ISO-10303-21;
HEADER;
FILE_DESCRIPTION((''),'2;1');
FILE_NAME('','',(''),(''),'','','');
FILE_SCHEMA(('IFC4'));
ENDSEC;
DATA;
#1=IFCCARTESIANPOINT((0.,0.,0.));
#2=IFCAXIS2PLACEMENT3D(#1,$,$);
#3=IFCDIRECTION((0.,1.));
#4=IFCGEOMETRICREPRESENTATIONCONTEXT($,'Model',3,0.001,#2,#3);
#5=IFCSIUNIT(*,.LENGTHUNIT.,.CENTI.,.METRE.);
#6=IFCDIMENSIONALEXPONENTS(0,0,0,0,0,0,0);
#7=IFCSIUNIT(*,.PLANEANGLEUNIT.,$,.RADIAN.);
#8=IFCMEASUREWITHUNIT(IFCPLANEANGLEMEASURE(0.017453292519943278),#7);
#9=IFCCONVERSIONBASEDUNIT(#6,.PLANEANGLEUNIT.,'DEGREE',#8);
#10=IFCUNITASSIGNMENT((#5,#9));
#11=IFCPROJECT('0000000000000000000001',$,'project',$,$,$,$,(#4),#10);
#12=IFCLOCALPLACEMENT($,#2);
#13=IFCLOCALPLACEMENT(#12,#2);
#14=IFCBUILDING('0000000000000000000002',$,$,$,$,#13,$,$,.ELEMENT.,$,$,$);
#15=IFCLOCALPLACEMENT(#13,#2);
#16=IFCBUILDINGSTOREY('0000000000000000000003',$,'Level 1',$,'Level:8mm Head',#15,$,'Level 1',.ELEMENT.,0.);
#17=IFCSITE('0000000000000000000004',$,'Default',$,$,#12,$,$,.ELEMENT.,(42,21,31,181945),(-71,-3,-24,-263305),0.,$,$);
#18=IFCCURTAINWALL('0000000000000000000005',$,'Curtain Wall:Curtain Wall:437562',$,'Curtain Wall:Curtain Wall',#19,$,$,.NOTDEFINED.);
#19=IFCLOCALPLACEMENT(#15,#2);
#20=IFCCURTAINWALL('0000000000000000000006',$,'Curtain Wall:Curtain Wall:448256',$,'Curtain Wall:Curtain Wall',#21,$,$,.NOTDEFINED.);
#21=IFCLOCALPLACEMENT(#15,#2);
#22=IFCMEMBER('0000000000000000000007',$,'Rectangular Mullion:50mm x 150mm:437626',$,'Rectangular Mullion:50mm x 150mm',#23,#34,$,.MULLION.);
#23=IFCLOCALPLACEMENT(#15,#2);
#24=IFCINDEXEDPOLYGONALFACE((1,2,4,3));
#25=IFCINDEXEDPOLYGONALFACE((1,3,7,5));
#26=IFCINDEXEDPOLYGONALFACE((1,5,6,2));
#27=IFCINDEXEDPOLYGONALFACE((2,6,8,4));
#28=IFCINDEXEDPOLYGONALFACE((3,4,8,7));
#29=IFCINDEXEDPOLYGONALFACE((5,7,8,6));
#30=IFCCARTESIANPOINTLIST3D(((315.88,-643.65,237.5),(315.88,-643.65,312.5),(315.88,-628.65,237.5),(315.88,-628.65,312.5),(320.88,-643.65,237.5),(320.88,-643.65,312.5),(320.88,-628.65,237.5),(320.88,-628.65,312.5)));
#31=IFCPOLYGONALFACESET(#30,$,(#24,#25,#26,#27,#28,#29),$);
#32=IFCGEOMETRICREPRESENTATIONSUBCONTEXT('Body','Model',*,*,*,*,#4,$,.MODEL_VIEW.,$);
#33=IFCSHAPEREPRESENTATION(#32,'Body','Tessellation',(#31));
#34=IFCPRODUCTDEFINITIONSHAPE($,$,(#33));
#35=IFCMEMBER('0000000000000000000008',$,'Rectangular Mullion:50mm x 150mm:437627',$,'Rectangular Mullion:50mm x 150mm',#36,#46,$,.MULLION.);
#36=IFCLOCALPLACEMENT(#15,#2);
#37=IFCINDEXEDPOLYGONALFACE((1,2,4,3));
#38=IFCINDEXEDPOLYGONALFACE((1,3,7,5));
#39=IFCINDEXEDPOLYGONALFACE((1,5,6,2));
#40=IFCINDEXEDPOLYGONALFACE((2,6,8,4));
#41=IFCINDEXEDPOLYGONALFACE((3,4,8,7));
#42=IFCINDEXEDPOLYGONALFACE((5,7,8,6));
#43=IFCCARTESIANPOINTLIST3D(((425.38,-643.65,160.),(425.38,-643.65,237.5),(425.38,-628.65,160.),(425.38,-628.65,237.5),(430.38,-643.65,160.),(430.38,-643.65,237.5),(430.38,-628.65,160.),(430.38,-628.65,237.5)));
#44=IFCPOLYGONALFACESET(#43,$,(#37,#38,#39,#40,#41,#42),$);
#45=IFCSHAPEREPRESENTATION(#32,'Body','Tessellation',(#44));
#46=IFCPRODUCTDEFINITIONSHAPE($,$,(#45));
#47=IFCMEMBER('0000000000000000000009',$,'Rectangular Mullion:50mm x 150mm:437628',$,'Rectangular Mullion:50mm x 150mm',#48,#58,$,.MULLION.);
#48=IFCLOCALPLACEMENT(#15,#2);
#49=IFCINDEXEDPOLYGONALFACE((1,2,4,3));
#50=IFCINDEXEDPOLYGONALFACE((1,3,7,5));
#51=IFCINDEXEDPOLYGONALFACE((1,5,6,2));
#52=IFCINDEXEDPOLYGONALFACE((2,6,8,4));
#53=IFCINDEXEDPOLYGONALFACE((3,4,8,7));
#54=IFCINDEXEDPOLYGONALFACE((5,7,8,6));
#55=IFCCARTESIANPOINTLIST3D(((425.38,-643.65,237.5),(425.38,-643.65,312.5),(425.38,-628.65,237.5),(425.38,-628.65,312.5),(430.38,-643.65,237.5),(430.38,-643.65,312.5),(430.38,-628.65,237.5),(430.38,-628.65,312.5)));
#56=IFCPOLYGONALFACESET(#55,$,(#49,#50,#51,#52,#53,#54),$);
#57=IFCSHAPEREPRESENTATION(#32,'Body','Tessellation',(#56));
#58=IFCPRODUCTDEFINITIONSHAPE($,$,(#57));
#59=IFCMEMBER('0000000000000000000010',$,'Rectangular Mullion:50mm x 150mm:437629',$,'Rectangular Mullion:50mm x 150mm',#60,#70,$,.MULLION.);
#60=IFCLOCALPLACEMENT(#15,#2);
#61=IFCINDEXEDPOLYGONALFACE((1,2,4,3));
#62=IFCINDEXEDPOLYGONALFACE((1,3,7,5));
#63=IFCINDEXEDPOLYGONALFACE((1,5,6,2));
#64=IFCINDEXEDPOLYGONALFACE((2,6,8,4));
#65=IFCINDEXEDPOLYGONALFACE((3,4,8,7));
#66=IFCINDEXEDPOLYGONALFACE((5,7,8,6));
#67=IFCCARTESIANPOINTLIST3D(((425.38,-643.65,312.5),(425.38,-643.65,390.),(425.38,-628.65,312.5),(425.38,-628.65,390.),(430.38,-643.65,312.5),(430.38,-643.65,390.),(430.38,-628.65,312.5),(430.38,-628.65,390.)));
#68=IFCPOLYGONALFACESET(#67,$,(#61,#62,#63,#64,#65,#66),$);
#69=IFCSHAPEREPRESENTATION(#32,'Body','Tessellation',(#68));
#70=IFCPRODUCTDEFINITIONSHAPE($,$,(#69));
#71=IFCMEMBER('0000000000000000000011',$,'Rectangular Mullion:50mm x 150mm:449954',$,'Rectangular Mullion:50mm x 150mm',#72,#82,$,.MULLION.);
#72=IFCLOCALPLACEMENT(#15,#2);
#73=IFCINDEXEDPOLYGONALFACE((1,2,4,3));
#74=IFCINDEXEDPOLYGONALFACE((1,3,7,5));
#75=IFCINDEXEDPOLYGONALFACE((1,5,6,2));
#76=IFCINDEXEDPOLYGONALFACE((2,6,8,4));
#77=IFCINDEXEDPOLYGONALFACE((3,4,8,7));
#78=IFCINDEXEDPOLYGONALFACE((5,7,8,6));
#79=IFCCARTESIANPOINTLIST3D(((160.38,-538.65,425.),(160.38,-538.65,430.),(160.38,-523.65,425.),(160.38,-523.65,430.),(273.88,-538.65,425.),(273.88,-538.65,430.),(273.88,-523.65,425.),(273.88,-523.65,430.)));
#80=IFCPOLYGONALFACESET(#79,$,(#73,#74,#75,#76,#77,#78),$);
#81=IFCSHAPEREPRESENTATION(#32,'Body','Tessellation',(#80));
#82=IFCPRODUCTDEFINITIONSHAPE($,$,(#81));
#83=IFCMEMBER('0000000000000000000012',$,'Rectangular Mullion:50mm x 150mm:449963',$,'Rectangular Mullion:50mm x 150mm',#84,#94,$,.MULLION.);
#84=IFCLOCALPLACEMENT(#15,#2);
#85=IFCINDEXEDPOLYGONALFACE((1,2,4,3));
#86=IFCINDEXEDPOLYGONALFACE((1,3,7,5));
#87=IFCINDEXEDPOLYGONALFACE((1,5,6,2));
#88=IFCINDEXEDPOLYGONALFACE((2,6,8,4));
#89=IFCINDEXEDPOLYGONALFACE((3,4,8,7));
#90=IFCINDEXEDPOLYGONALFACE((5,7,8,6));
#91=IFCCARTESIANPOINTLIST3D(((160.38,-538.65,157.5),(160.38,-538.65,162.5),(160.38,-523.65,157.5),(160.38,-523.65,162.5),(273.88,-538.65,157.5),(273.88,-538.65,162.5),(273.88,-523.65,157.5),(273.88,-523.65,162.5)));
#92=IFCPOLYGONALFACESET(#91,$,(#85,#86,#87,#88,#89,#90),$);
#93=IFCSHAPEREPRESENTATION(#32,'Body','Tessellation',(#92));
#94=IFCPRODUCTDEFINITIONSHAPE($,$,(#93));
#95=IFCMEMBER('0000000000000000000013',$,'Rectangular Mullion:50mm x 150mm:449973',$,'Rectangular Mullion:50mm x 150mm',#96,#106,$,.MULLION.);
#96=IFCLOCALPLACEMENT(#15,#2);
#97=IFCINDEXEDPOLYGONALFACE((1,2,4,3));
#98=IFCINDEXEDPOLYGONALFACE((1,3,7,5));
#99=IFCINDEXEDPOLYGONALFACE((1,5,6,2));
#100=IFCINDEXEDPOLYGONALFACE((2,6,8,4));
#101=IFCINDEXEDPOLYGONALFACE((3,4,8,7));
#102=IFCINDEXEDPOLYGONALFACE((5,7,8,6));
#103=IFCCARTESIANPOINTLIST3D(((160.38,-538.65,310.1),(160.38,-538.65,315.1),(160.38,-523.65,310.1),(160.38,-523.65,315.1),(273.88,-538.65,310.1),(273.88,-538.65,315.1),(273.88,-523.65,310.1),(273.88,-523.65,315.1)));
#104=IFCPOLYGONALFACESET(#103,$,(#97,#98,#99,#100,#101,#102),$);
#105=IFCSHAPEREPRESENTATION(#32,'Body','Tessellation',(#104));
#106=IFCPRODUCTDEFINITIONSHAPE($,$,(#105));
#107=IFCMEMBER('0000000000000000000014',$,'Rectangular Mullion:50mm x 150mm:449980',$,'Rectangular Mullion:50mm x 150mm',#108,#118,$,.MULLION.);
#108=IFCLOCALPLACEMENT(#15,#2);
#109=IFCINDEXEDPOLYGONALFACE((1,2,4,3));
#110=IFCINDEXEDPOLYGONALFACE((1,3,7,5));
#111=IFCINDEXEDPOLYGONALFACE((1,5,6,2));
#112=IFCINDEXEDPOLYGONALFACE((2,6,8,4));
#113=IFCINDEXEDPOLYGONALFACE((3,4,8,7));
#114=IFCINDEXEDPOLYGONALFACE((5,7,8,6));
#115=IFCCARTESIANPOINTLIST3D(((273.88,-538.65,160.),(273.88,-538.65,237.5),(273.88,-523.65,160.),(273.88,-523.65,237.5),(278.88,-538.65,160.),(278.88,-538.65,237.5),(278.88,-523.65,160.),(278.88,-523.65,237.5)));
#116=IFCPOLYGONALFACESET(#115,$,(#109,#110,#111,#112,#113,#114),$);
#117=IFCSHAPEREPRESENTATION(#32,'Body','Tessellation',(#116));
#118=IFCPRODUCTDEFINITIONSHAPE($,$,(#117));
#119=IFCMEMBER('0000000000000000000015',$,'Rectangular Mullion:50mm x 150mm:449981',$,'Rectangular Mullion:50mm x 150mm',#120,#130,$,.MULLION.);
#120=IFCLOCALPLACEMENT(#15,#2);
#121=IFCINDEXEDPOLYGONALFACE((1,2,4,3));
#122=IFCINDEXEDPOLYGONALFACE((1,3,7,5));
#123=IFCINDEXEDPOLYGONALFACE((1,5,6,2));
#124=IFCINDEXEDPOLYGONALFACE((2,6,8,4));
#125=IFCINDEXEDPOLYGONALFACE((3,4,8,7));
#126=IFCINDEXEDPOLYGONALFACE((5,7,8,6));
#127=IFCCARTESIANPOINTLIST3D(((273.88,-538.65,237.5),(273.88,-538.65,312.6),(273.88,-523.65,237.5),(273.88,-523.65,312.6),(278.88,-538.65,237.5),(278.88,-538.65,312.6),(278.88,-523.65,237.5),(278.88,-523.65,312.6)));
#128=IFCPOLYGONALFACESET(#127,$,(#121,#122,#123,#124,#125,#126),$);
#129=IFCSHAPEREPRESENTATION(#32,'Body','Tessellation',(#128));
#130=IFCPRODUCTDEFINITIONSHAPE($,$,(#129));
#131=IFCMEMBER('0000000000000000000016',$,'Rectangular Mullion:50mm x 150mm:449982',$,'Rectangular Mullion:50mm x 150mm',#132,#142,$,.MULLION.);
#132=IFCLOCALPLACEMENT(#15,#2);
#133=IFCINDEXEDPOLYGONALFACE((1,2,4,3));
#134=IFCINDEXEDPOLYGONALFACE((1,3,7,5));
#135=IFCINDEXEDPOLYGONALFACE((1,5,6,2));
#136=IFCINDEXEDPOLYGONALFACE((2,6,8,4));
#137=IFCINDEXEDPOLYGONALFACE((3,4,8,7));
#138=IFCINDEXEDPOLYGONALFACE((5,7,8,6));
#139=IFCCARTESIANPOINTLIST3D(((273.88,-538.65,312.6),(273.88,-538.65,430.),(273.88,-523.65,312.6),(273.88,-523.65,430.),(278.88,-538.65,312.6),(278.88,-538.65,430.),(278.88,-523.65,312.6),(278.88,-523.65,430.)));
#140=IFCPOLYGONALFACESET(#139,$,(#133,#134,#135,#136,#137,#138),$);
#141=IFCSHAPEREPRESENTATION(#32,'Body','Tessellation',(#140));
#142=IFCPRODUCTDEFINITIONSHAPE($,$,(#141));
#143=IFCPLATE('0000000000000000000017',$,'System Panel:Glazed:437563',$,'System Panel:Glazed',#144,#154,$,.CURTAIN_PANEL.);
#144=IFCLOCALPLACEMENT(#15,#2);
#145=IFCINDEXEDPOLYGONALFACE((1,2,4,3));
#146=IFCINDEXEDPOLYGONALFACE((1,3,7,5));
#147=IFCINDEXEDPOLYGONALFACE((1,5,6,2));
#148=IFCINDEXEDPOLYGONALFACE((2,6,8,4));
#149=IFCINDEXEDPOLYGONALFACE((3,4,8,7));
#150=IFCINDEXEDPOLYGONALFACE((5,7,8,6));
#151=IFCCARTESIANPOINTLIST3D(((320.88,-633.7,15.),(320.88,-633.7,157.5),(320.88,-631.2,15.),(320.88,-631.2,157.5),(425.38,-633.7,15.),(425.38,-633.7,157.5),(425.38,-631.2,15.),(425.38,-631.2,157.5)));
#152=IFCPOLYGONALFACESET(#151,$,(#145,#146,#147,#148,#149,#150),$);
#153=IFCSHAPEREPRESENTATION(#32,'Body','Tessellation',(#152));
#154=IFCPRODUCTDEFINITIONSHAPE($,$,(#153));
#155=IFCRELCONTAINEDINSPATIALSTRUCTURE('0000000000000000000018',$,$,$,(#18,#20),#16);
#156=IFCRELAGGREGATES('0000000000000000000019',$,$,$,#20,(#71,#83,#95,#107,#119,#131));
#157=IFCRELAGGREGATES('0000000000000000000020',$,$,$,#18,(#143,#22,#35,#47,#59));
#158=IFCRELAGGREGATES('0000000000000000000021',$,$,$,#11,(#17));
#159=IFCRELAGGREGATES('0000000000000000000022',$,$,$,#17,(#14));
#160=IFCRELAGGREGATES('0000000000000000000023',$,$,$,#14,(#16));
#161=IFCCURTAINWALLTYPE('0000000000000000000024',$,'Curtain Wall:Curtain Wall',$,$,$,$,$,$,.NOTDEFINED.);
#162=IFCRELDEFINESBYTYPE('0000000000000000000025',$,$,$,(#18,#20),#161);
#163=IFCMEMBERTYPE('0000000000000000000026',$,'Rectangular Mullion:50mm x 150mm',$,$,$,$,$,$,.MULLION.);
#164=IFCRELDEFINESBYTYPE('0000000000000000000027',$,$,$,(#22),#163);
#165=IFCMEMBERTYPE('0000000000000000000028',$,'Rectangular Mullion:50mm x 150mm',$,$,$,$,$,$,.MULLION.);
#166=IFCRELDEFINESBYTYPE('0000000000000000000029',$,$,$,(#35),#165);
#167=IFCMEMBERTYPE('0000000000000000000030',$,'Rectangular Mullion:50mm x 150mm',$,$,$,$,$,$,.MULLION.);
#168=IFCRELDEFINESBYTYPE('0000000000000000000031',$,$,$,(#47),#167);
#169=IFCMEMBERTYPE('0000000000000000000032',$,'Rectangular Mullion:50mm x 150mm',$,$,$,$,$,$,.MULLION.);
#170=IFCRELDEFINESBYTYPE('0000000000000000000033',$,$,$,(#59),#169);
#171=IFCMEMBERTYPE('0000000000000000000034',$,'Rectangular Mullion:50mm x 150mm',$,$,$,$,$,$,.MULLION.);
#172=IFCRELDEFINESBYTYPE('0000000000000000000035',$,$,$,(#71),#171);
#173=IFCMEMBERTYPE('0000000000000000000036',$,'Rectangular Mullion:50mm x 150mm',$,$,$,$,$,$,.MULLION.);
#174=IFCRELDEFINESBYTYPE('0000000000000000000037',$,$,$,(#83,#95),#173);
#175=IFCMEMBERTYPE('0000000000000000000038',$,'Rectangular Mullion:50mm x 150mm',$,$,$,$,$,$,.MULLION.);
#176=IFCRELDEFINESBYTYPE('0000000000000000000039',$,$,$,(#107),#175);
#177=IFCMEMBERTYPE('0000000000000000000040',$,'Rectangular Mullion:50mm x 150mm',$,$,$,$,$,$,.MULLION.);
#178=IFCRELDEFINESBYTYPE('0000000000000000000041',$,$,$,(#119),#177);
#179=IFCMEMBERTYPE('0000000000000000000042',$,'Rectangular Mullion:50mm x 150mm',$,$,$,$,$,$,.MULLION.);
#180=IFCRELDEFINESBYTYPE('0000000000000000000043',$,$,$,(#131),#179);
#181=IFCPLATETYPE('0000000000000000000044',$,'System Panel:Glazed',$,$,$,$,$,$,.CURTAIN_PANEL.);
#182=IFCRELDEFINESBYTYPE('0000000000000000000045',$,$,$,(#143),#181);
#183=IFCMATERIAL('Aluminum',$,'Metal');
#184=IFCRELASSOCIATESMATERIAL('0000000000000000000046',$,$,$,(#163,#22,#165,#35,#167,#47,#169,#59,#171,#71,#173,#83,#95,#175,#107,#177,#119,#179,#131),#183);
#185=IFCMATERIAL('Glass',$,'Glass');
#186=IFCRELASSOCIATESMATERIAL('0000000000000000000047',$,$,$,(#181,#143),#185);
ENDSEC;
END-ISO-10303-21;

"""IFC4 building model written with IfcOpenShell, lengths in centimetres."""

from ifc_helpers import new_model, entity, si_unit, converted_unit, direction, frame, origin, place, context, subcontext, project, spatial, indexed_curve, outline, extrude, source, transform, mapped, material, type_object, type_shapes, element, aggregate, save


model = new_model("IFC4")

# Units and contexts
model_context = context("Model", 3, precision=0.001, world=origin(), true_north=direction((0.0, 1.0)))
body_context = subcontext(model_context, "Body", "Model", "MODEL_VIEW")
ifc_project = project(units=[si_unit("LENGTHUNIT", "METRE", prefix="CENTI"), converted_unit("PLANEANGLEUNIT", "DEGREE", entity("IfcPlaneAngleMeasure", 0.017453292519943278), si_unit("PLANEANGLEUNIT", "RADIAN"), dimensions=[0, 0, 0, 0, 0, 0, 0])], contexts=[model_context])

# Site, building, storey
site_placement = place(None, origin())
site = spatial("IfcSite", under=ifc_project, at=site_placement, Name="Default", CompositionType="ELEMENT", RefLatitude=(42, 21, 31, 181945), RefLongitude=(-71, -3, -24, -263305), RefElevation=0.0)
building_placement = place(site_placement, origin())
building = spatial("IfcBuilding", under=site, at=building_placement, CompositionType="ELEMENT")
storey_placement = place(building_placement, origin())
storey = spatial("IfcBuildingStorey", under=building, at=storey_placement, Name="Level 1", ObjectType="Level:8mm Head", LongName="Level 1", CompositionType="ELEMENT", Elevation=0.0)

# Curtain wall
curtain_wall_type = type_object("IfcCurtainWallType", Name="Curtain Wall:Curtain Wall", PredefinedType="NOTDEFINED")
curtain_wall_1_placement = place(storey_placement, origin())
curtain_wall_1 = element("IfcCurtainWall", 1, at=curtain_wall_1_placement, inside=storey, type_object=curtain_wall_type, Name="Curtain Wall:Curtain Wall:437562", ObjectType="Curtain Wall:Curtain Wall", PredefinedType="NOTDEFINED")
ifc_material_1 = material(Name="Aluminum", Category="Metal")

# Curtain wall
curtain_wall_2_placement = place(storey_placement, origin())
curtain_wall_2 = element("IfcCurtainWall", 2, at=curtain_wall_2_placement, inside=storey, type_object=curtain_wall_type, Name="Curtain Wall:Curtain Wall:448256", ObjectType="Curtain Wall:Curtain Wall", PredefinedType="NOTDEFINED")

# Members
member_type_1 = type_object("IfcMemberType", Name="Rectangular Mullion:50mm x 150mm", PredefinedType="MULLION", material=ifc_material_1)
shared_shape_1 = source(origin(), body_context, "Body", "SweptSolid", [
    extrude(outline(indexed_curve([(-2.5, -7.5), (2.5, -7.5), (2.5, 7.5), (-2.5, 7.5), (-2.5, -7.5)], self_intersect=False)), frame((-2.5, 0.0, -75.0), z_axis=(0.0, 0.0, 1.0), x_axis=(-1.0, 0.0, 0.0)), (0.0, 0.0, 1.0), 75.0),
])
type_shapes(member_type_1, [shared_shape_1])
member_1_placement = place(curtain_wall_1_placement, frame((315.88, -636.15, 312.5), z_axis=(0.0, 0.0, 1.0), x_axis=(-1.0, 0.0, 0.0)))
member_1 = element("IfcMember", 3, at=member_1_placement, type_object=member_type_1, material=ifc_material_1, Name="Rectangular Mullion:50mm x 150mm:437626", ObjectType="Rectangular Mullion:50mm x 150mm", PredefinedType="MULLION", context=body_context, shape_type="MappedRepresentation", body=[
    mapped(shared_shape_1, transform((0.0, 0.0, 0.0), scale=1.0)),
])
member_type_2 = type_object("IfcMemberType", Name="Rectangular Mullion:50mm x 150mm", PredefinedType="MULLION", material=ifc_material_1)
shared_shape_2 = source(origin(), body_context, "Body", "SweptSolid", [
    extrude(outline(indexed_curve([(-2.5, -7.5), (2.5, -7.5), (2.5, 7.5), (-2.5, 7.5), (-2.5, -7.5)], self_intersect=False)), frame((0.0, 0.0, -77.5), z_axis=(0.0, 0.0, 1.0), x_axis=(-1.0, 0.0, 0.0)), (0.0, 0.0, 1.0), 77.5),
])
type_shapes(member_type_2, [shared_shape_2])
member_2_placement = place(curtain_wall_1_placement, frame((427.88, -636.15, 160.0), z_axis=(0.0, 0.0, -1.0), x_axis=(1.0, 0.0, 0.0)))
member_2 = element("IfcMember", 4, at=member_2_placement, type_object=member_type_2, material=ifc_material_1, Name="Rectangular Mullion:50mm x 150mm:437627", ObjectType="Rectangular Mullion:50mm x 150mm", PredefinedType="MULLION", context=body_context, shape_type="MappedRepresentation", body=[
    mapped(shared_shape_2, transform((0.0, 0.0, 0.0), scale=1.0)),
])
member_type_3 = type_object("IfcMemberType", Name="Rectangular Mullion:50mm x 150mm", PredefinedType="MULLION", material=ifc_material_1)
shared_shape_3 = source(origin(), body_context, "Body", "SweptSolid", [
    extrude(outline(indexed_curve([(-2.5, -7.5), (2.5, -7.5), (2.5, 7.5), (-2.5, 7.5), (-2.5, -7.5)], self_intersect=False)), frame((0.0, 0.0, -75.0), z_axis=(0.0, 0.0, 1.0), x_axis=(-1.0, 0.0, 0.0)), (0.0, 0.0, 1.0), 75.0),
])
type_shapes(member_type_3, [shared_shape_3])
member_3_placement = place(curtain_wall_1_placement, frame((427.88, -636.15, 237.5), z_axis=(0.0, 0.0, -1.0), x_axis=(1.0, 0.0, 0.0)))
member_3 = element("IfcMember", 5, at=member_3_placement, type_object=member_type_3, material=ifc_material_1, Name="Rectangular Mullion:50mm x 150mm:437628", ObjectType="Rectangular Mullion:50mm x 150mm", PredefinedType="MULLION", context=body_context, shape_type="MappedRepresentation", body=[
    mapped(shared_shape_3, transform((0.0, 0.0, 0.0), scale=1.0)),
])
member_type_4 = type_object("IfcMemberType", Name="Rectangular Mullion:50mm x 150mm", PredefinedType="MULLION", material=ifc_material_1)
shared_shape_4 = source(origin(), body_context, "Body", "SweptSolid", [
    extrude(outline(indexed_curve([(-2.5, -7.5), (2.5, -7.5), (2.5, 7.5), (-2.5, 7.5), (-2.5, -7.5)], self_intersect=False)), frame((0.0, 0.0, -77.5), z_axis=(0.0, 0.0, 1.0), x_axis=(-1.0, 0.0, 0.0)), (0.0, 0.0, 1.0), 77.5),
])
type_shapes(member_type_4, [shared_shape_4])
member_4_placement = place(curtain_wall_1_placement, frame((427.88, -636.15, 312.5), z_axis=(0.0, 0.0, -1.0), x_axis=(1.0, 0.0, 0.0)))
member_4 = element("IfcMember", 6, at=member_4_placement, type_object=member_type_4, material=ifc_material_1, Name="Rectangular Mullion:50mm x 150mm:437629", ObjectType="Rectangular Mullion:50mm x 150mm", PredefinedType="MULLION", context=body_context, shape_type="MappedRepresentation", body=[
    mapped(shared_shape_4, transform((0.0, 0.0, 0.0), scale=1.0)),
])
member_type_5 = type_object("IfcMemberType", Name="Rectangular Mullion:50mm x 150mm", PredefinedType="MULLION", material=ifc_material_1)
shared_shape_5 = source(origin(), body_context, "Body", "SweptSolid", [
    extrude(outline(indexed_curve([(-2.5, -7.5), (2.5, -7.5), (2.5, 7.5), (-2.5, 7.5), (-2.5, -7.5)], self_intersect=False)), frame((-2.5, 0.0, -113.5), z_axis=(0.0, 0.0, 1.0), x_axis=(-1.0, 0.0, 0.0)), (0.0, 0.0, 1.0), 113.5),
])
type_shapes(member_type_5, [shared_shape_5])
member_5_placement = place(curtain_wall_2_placement, frame((273.88, -531.15, 430.0), z_axis=(1.0, 0.0, 0.0), x_axis=(0.0, 0.0, 1.0)))
member_5 = element("IfcMember", 7, at=member_5_placement, type_object=member_type_5, material=ifc_material_1, Name="Rectangular Mullion:50mm x 150mm:449954", ObjectType="Rectangular Mullion:50mm x 150mm", PredefinedType="MULLION", context=body_context, shape_type="MappedRepresentation", body=[
    mapped(shared_shape_5, transform((0.0, 0.0, 0.0), scale=1.0)),
])
member_type_6 = type_object("IfcMemberType", Name="Rectangular Mullion:50mm x 150mm", PredefinedType="MULLION", material=ifc_material_1)
shared_shape_6 = source(origin(), body_context, "Body", "SweptSolid", [
    extrude(outline(indexed_curve([(-2.5, -7.5), (2.5, -7.5), (2.5, 7.5), (-2.5, 7.5), (-2.5, -7.5)], self_intersect=False)), frame((0.0, 0.0, -113.5), z_axis=(0.0, 0.0, 1.0), x_axis=(-1.0, 0.0, 0.0)), (0.0, 0.0, 1.0), 113.5),
])
type_shapes(member_type_6, [shared_shape_6])
member_6_placement = place(curtain_wall_2_placement, frame((273.88, -531.15, 160.0), z_axis=(1.0, 0.0, 0.0), x_axis=(0.0, 0.0, 1.0)))
member_6 = element("IfcMember", 8, at=member_6_placement, type_object=member_type_6, material=ifc_material_1, Name="Rectangular Mullion:50mm x 150mm:449963", ObjectType="Rectangular Mullion:50mm x 150mm", PredefinedType="MULLION", context=body_context, shape_type="MappedRepresentation", body=[
    mapped(shared_shape_6, transform((0.0, 0.0, 0.0), scale=1.0)),
])
member_7_placement = place(curtain_wall_2_placement, frame((273.88, -531.15, 312.6), z_axis=(1.0, 0.0, 0.0), x_axis=(0.0, 0.0, 1.0)))
member_7 = element("IfcMember", 9, at=member_7_placement, type_object=member_type_6, material=ifc_material_1, Name="Rectangular Mullion:50mm x 150mm:449973", ObjectType="Rectangular Mullion:50mm x 150mm", PredefinedType="MULLION", context=body_context, shape_type="MappedRepresentation", body=[
    mapped(shared_shape_6, transform((0.0, 0.0, 0.0), scale=1.0)),
])
member_type_7 = type_object("IfcMemberType", Name="Rectangular Mullion:50mm x 150mm", PredefinedType="MULLION", material=ifc_material_1)
shared_shape_7 = source(origin(), body_context, "Body", "SweptSolid", [
    extrude(outline(indexed_curve([(-2.5, -7.5), (2.5, -7.5), (2.5, 7.5), (-2.5, 7.5), (-2.5, -7.5)], self_intersect=False)), frame((-2.5, 0.0, -77.5), z_axis=(0.0, 0.0, 1.0), x_axis=(-1.0, 0.0, 0.0)), (0.0, 0.0, 1.0), 77.5),
])
type_shapes(member_type_7, [shared_shape_7])
member_8_placement = place(curtain_wall_2_placement, frame((278.88, -531.15, 160.0), z_axis=(0.0, 0.0, -1.0), x_axis=(1.0, 0.0, 0.0)))
member_8 = element("IfcMember", 10, at=member_8_placement, type_object=member_type_7, material=ifc_material_1, Name="Rectangular Mullion:50mm x 150mm:449980", ObjectType="Rectangular Mullion:50mm x 150mm", PredefinedType="MULLION", context=body_context, shape_type="MappedRepresentation", body=[
    mapped(shared_shape_7, transform((0.0, 0.0, 0.0), scale=1.0)),
])
member_type_8 = type_object("IfcMemberType", Name="Rectangular Mullion:50mm x 150mm", PredefinedType="MULLION", material=ifc_material_1)
shared_shape_8 = source(origin(), body_context, "Body", "SweptSolid", [
    extrude(outline(indexed_curve([(-2.5, -7.5), (2.5, -7.5), (2.5, 7.5), (-2.5, 7.5), (-2.5, -7.5)], self_intersect=False)), frame((-2.5, 0.0, -75.1), z_axis=(0.0, 0.0, 1.0), x_axis=(-1.0, 0.0, 0.0)), (0.0, 0.0, 1.0), 75.1),
])
type_shapes(member_type_8, [shared_shape_8])
member_9_placement = place(curtain_wall_2_placement, frame((278.88, -531.15, 237.5), z_axis=(0.0, 0.0, -1.0), x_axis=(1.0, 0.0, 0.0)))
member_9 = element("IfcMember", 11, at=member_9_placement, type_object=member_type_8, material=ifc_material_1, Name="Rectangular Mullion:50mm x 150mm:449981", ObjectType="Rectangular Mullion:50mm x 150mm", PredefinedType="MULLION", context=body_context, shape_type="MappedRepresentation", body=[
    mapped(shared_shape_8, transform((0.0, 0.0, 0.0), scale=1.0)),
])
member_type_9 = type_object("IfcMemberType", Name="Rectangular Mullion:50mm x 150mm", PredefinedType="MULLION", material=ifc_material_1)
shared_shape_9 = source(origin(), body_context, "Body", "SweptSolid", [
    extrude(outline(indexed_curve([(-2.5, -7.5), (2.5, -7.5), (2.5, 7.5), (-2.5, 7.5), (-2.5, -7.5)], self_intersect=False)), frame((-2.5, 0.0, -117.4), z_axis=(0.0, 0.0, 1.0), x_axis=(-1.0, 0.0, 0.0)), (0.0, 0.0, 1.0), 117.4),
])
type_shapes(member_type_9, [shared_shape_9])
member_10_placement = place(curtain_wall_2_placement, frame((278.88, -531.15, 312.6), z_axis=(0.0, 0.0, -1.0), x_axis=(1.0, 0.0, 0.0)))
member_10 = element("IfcMember", 12, at=member_10_placement, type_object=member_type_9, material=ifc_material_1, Name="Rectangular Mullion:50mm x 150mm:449982", ObjectType="Rectangular Mullion:50mm x 150mm", PredefinedType="MULLION", context=body_context, shape_type="MappedRepresentation", body=[
    mapped(shared_shape_9, transform((0.0, 0.0, 0.0), scale=1.0)),
])
aggregate(curtain_wall_2, [member_5, member_6, member_7, member_8, member_9, member_10])

# Plate
ifc_material_2 = material(Name="Glass", Category="Glass")
plate_type_1 = type_object("IfcPlateType", Name="System Panel:Glazed", PredefinedType="CURTAIN_PANEL", material=ifc_material_2)
shared_shape_10 = source(origin(), body_context, "Body", "SweptSolid", [
    extrude(outline(indexed_curve([(-1.25, -52.25), (1.25, -52.25), (1.25, 52.25), (-1.25, 52.25), (-1.25, -52.25)], self_intersect=False)), frame((0.0, 3.7, 0.0), z_axis=(0.0, 0.0, 1.0), x_axis=(0.0, 1.0, 0.0)), (0.0, 0.0, 1.0), 142.5),
])
type_shapes(plate_type_1, [shared_shape_10])
plate_1_placement = place(curtain_wall_1_placement, frame((373.13, -636.15, 15.0)))
plate_1 = element("IfcPlate", 13, at=plate_1_placement, type_object=plate_type_1, material=ifc_material_2, Name="System Panel:Glazed:437563", ObjectType="System Panel:Glazed", PredefinedType="CURTAIN_PANEL", context=body_context, shape_type="MappedRepresentation", body=[
    mapped(shared_shape_10, transform((0.0, 0.0, 0.0), scale=1.0)),
])
aggregate(curtain_wall_1, [plate_1, member_1, member_2, member_3, member_4])

save(model, "model.ifc")
